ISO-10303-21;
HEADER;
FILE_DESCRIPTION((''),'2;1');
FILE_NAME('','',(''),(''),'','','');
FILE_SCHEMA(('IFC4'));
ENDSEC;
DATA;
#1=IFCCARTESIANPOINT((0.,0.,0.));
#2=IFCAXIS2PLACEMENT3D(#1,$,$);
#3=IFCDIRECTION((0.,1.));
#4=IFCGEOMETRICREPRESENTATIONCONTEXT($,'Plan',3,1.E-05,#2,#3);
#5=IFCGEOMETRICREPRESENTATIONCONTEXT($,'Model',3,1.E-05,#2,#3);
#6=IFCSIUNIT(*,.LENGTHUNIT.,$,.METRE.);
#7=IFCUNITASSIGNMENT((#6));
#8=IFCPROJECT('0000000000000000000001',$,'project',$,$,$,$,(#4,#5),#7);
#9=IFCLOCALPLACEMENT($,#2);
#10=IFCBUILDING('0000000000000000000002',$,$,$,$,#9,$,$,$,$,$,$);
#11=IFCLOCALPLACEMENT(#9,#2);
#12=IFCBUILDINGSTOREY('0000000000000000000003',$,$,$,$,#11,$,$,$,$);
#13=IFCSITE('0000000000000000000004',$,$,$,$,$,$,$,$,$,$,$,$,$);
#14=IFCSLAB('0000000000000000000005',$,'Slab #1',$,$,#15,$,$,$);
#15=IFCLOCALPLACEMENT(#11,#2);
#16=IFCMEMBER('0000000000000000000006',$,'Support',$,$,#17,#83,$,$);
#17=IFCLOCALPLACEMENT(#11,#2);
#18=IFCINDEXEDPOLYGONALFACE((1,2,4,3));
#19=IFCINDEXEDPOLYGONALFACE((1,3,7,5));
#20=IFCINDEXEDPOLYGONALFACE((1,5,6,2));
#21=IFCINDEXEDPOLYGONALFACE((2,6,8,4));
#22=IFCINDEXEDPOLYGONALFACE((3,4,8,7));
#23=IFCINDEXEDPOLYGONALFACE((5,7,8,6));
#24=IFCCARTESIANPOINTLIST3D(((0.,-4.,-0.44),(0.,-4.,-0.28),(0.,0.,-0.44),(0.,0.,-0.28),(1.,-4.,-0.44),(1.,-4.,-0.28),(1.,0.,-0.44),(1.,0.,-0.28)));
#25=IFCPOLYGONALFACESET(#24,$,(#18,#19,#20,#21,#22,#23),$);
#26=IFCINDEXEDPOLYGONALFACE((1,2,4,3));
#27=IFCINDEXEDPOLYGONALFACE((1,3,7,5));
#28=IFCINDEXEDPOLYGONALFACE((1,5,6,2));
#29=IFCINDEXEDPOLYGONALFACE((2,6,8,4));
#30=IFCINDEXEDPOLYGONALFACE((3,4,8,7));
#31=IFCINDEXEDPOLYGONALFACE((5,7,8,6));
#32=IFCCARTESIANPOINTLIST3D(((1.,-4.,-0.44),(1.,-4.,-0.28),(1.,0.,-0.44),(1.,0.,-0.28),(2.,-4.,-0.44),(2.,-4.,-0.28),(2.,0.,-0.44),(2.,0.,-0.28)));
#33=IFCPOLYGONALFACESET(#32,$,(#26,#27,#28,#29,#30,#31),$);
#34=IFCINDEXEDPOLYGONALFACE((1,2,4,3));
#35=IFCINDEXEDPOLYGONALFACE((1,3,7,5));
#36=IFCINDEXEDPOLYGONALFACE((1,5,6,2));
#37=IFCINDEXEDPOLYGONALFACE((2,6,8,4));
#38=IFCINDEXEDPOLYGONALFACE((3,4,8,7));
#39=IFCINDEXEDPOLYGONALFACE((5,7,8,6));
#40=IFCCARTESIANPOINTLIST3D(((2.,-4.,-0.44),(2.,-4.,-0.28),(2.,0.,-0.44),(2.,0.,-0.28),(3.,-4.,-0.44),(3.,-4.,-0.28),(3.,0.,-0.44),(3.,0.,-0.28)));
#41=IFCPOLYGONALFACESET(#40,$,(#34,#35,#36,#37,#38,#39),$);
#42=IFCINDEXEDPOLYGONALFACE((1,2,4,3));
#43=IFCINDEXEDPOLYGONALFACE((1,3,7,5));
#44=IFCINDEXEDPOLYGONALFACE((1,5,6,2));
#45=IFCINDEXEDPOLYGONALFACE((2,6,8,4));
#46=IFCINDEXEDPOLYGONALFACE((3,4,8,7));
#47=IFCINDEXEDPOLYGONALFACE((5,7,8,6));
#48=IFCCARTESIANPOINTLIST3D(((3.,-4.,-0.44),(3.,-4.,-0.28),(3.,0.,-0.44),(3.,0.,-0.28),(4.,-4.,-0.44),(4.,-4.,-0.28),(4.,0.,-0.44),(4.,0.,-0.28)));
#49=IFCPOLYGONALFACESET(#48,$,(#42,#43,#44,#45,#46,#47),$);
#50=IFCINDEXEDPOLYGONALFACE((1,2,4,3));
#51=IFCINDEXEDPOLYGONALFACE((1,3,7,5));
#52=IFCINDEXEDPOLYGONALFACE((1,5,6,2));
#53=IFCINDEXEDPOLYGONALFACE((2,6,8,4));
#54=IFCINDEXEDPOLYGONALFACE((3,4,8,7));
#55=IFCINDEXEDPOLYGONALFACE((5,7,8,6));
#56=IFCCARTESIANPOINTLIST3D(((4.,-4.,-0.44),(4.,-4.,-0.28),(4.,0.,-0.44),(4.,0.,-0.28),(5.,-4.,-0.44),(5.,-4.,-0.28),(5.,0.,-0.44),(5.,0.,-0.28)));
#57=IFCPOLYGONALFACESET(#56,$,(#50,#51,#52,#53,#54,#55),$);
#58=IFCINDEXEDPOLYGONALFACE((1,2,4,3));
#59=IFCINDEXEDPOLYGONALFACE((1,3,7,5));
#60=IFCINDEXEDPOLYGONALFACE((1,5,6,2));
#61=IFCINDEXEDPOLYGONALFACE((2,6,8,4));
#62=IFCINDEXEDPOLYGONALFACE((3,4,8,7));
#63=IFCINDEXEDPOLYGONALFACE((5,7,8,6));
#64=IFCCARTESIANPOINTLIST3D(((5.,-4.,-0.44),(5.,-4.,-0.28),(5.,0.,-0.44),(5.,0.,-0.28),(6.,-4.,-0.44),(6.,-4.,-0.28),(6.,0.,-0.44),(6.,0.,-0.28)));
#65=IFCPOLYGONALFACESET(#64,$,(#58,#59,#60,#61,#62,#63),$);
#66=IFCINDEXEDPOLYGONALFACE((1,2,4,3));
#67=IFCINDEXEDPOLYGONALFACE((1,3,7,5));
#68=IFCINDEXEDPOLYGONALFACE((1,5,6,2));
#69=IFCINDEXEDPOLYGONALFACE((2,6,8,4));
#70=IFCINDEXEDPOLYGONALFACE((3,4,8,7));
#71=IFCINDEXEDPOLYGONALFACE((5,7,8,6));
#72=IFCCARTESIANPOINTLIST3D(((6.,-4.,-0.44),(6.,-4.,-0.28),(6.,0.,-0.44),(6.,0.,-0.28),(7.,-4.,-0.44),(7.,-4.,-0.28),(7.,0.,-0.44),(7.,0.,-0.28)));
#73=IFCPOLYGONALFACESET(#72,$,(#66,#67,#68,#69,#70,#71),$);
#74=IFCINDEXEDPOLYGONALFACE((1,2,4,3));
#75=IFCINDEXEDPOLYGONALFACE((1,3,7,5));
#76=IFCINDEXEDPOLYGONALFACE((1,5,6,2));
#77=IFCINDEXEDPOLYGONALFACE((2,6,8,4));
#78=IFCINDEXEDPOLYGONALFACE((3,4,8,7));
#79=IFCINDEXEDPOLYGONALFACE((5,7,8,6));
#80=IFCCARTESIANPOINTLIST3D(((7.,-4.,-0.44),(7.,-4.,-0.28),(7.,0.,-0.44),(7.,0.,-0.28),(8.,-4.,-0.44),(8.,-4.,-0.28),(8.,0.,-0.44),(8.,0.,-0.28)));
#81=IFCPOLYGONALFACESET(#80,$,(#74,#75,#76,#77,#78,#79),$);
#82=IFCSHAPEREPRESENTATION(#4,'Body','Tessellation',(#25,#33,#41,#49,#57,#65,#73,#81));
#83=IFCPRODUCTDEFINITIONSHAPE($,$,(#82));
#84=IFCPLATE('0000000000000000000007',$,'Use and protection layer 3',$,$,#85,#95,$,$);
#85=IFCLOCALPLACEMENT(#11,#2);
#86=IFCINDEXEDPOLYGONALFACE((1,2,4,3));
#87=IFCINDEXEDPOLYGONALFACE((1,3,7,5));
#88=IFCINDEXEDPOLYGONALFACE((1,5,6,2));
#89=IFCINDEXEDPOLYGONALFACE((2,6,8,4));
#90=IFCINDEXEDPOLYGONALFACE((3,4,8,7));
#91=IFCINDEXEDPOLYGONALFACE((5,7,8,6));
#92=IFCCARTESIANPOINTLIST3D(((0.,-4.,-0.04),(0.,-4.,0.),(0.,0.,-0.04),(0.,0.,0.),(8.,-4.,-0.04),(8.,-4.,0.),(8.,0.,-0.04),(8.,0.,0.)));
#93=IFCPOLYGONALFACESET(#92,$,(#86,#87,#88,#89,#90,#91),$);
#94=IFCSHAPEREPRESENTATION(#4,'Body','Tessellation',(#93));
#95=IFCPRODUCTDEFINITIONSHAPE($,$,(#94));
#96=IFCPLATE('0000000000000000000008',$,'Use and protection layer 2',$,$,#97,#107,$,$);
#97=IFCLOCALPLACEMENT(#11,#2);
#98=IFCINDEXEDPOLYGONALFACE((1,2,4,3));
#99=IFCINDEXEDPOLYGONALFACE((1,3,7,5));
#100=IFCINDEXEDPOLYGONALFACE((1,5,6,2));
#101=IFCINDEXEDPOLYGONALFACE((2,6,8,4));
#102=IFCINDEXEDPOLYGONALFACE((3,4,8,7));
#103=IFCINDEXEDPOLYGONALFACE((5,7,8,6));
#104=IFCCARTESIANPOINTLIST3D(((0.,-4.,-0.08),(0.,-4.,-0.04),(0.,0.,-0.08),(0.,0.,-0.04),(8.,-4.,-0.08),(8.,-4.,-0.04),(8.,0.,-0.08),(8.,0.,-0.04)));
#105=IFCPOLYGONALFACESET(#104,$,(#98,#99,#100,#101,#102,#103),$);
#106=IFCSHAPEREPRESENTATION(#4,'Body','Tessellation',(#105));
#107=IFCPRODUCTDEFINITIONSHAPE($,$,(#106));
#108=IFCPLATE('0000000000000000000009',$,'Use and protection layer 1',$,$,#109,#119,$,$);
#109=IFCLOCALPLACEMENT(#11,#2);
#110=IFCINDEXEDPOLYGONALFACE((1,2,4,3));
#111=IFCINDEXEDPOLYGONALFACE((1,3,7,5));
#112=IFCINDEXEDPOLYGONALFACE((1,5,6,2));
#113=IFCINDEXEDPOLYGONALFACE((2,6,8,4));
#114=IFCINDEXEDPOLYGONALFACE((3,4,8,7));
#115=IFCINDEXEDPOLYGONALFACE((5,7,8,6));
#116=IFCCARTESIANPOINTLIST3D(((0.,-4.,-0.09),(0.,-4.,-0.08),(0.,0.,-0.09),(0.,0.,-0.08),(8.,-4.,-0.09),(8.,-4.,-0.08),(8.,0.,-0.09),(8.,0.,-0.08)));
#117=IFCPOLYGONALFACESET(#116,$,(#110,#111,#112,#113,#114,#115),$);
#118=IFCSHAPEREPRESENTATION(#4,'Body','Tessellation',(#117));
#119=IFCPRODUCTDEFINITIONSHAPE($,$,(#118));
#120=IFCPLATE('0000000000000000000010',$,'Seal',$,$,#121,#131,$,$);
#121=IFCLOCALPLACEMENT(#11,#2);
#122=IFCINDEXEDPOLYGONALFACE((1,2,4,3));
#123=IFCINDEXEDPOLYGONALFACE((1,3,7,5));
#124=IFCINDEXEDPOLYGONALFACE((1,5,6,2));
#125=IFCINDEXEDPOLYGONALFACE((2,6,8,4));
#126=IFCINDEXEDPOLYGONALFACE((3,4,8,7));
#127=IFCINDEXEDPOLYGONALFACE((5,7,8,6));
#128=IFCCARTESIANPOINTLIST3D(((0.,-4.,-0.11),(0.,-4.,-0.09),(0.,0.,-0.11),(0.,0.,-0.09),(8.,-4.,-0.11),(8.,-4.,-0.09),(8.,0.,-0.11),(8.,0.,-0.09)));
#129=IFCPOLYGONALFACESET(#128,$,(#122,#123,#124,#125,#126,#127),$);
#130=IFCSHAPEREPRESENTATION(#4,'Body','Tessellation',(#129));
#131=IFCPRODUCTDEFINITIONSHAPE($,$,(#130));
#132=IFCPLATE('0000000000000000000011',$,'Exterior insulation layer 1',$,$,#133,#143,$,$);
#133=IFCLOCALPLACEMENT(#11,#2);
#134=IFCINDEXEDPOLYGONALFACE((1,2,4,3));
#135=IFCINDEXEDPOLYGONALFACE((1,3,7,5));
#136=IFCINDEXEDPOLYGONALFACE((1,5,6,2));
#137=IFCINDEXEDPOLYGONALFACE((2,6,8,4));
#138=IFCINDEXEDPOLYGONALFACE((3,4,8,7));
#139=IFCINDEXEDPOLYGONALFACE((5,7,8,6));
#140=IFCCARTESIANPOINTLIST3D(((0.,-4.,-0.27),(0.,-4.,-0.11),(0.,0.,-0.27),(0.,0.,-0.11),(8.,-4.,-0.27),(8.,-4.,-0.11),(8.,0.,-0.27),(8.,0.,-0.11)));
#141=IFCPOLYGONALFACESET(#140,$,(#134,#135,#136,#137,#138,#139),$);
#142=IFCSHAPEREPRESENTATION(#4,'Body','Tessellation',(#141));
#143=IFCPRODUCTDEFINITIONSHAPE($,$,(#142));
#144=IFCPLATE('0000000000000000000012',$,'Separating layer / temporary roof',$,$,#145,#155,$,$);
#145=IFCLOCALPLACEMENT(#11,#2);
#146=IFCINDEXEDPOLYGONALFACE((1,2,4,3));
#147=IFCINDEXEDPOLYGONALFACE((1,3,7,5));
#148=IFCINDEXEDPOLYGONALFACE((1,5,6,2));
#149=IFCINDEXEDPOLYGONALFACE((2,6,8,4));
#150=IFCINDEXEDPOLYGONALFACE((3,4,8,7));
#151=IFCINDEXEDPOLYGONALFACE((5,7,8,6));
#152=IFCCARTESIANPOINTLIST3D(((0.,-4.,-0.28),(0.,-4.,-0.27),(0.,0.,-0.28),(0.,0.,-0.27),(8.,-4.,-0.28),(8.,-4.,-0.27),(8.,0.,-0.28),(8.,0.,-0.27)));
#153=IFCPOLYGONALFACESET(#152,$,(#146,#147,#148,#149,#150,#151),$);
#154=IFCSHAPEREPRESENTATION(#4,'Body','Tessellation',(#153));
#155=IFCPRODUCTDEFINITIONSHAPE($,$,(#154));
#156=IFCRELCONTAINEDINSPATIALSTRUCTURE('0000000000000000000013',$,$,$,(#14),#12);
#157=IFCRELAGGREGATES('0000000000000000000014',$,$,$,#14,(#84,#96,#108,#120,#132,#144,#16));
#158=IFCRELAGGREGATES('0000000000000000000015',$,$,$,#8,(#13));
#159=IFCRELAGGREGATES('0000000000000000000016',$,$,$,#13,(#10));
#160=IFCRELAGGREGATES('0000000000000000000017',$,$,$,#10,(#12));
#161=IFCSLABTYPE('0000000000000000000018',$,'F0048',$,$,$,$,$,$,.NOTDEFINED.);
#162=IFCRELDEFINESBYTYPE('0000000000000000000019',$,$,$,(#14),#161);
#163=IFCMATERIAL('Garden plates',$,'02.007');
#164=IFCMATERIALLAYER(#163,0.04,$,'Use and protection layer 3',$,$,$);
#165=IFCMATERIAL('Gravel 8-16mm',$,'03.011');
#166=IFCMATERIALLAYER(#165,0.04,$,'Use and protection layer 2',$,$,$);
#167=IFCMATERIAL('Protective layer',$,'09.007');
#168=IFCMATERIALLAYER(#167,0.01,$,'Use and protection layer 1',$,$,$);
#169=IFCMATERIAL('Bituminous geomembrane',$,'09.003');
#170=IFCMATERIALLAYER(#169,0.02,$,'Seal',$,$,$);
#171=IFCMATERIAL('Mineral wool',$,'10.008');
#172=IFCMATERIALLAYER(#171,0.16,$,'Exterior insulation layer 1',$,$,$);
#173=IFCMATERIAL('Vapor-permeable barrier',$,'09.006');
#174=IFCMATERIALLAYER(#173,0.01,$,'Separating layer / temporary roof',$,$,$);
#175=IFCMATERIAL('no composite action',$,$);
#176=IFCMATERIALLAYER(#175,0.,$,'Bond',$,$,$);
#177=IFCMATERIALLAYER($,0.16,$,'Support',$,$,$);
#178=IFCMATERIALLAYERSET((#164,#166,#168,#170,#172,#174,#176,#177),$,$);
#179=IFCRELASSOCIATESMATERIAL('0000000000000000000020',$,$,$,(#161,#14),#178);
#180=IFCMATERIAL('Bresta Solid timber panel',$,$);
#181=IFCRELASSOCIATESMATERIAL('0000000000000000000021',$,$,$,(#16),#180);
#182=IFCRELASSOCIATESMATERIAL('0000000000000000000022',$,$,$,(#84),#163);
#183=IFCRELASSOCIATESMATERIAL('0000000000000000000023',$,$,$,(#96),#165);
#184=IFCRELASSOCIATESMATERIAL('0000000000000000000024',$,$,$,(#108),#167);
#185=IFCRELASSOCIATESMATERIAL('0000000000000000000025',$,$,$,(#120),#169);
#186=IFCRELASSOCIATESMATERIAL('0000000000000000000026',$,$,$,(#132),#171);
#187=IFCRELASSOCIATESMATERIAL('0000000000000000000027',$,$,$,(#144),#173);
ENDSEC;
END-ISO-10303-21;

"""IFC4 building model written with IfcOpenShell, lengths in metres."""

from ifc_helpers import new_model, si_unit, direction, frame, frame_2d, origin, origin_with_axes, place, context, project, spatial, rectangle, extrude, material, layer, layer_set, type_object, element, aggregate, save


model = new_model("IFC4")

# Units and contexts
plan_context = context("Plan", 3, precision=1e-05, world=origin(), true_north=direction((0.0, 1.0)))
model_context = context("Model", 3, precision=1e-05, world=origin(), true_north=direction((0.0, 1.0)))
ifc_project = project(units=[si_unit("LENGTHUNIT", "METRE")], contexts=[plan_context, model_context])

# Site, building, storey
site = spatial("IfcSite", under=ifc_project)
building_placement = place(None, origin())
building = spatial("IfcBuilding", under=site, at=building_placement)
storey_placement = place(building_placement, origin())
storey = spatial("IfcBuildingStorey", under=building, at=storey_placement)

# Slab, member, plates
ifc_material_1 = material(Name="Garden plates", Category="02.007")
ifc_layer_1 = layer(ifc_material_1, 0.04, Name="Use and protection layer 3")
ifc_material_2 = material(Name="Gravel 8-16mm", Category="03.011")
ifc_layer_2 = layer(ifc_material_2, 0.04, Name="Use and protection layer 2")
ifc_material_3 = material(Name="Protective layer", Category="09.007")
ifc_layer_3 = layer(ifc_material_3, 0.01, Name="Use and protection layer 1")
ifc_material_4 = material(Name="Bituminous geomembrane", Category="09.003")
ifc_layer_4 = layer(ifc_material_4, 0.02, Name="Seal")
ifc_material_5 = material(Name="Mineral wool", Category="10.008")
ifc_layer_5 = layer(ifc_material_5, 0.16, Name="Exterior insulation layer 1")
ifc_material_6 = material(Name="Vapor-permeable barrier", Category="09.006")
ifc_layer_6 = layer(ifc_material_6, 0.01, Name="Separating layer / temporary roof")
ifc_material_7 = material(Name="no composite action")
ifc_layer_7 = layer(ifc_material_7, 0.0, Name="Bond")
ifc_layer_8 = layer(None, 0.16, Name="Support")
ifc_layer_set = layer_set([ifc_layer_1, ifc_layer_2, ifc_layer_3, ifc_layer_4, ifc_layer_5, ifc_layer_6, ifc_layer_7, ifc_layer_8])
slab_type = type_object("IfcSlabType", Name="F0048", PredefinedType="NOTDEFINED", material=ifc_layer_set)
slab_placement = place(None, frame((0.0, 0.0, 0.0), z_axis=(0.0, 0.0, -1.0), x_axis=(1.0, 0.0, 0.0)))
slab = element("IfcSlab", 1, at=slab_placement, inside=storey, type_object=slab_type, material=ifc_layer_set, Name="Slab #1")
ifc_material_8 = material(Name="Bresta Solid timber panel")
member_placement = place(slab_placement, origin())
member = element("IfcMember", 2, at=member_placement, material=ifc_material_8, Name="Support", context=plan_context, shape_type="SweptSolid", body=[
    extrude(rectangle(XDim=1.0, YDim=0.16, at=frame_2d((0.5, 0.08), x_axis=(1.0, 0.0))), frame((0.0, 4.0, 0.28), z_axis=(0.0, -1.0, 0.0), x_axis=(1.0, 0.0, 0.0)), (0.0, 0.0, 1.0), 4.0),
    extrude(rectangle(XDim=1.0, YDim=0.16, at=frame_2d((0.5, 0.08), x_axis=(1.0, 0.0))), frame((1.0, 4.0, 0.28), z_axis=(0.0, -1.0, 0.0), x_axis=(1.0, 0.0, 0.0)), (0.0, 0.0, 1.0), 4.0),
    extrude(rectangle(XDim=1.0, YDim=0.16, at=frame_2d((0.5, 0.08), x_axis=(1.0, 0.0))), frame((2.0, 4.0, 0.28), z_axis=(0.0, -1.0, 0.0), x_axis=(1.0, 0.0, 0.0)), (0.0, 0.0, 1.0), 4.0),
    extrude(rectangle(XDim=1.0, YDim=0.16, at=frame_2d((0.5, 0.08), x_axis=(1.0, 0.0))), frame((3.0, 4.0, 0.28), z_axis=(0.0, -1.0, 0.0), x_axis=(1.0, 0.0, 0.0)), (0.0, 0.0, 1.0), 4.0),
    extrude(rectangle(XDim=1.0, YDim=0.16, at=frame_2d((0.5, 0.08), x_axis=(1.0, 0.0))), frame((4.0, 4.0, 0.28), z_axis=(0.0, -1.0, 0.0), x_axis=(1.0, 0.0, 0.0)), (0.0, 0.0, 1.0), 4.0),
    extrude(rectangle(XDim=1.0, YDim=0.16, at=frame_2d((0.5, 0.08), x_axis=(1.0, 0.0))), frame((5.0, 4.0, 0.28), z_axis=(0.0, -1.0, 0.0), x_axis=(1.0, 0.0, 0.0)), (0.0, 0.0, 1.0), 4.0),
    extrude(rectangle(XDim=1.0, YDim=0.16, at=frame_2d((0.5, 0.08), x_axis=(1.0, 0.0))), frame((6.0, 4.0, 0.28), z_axis=(0.0, -1.0, 0.0), x_axis=(1.0, 0.0, 0.0)), (0.0, 0.0, 1.0), 4.0),
    extrude(rectangle(XDim=1.0, YDim=0.16, at=frame_2d((0.5, 0.08), x_axis=(1.0, 0.0))), frame((7.0, 4.0, 0.28), z_axis=(0.0, -1.0, 0.0), x_axis=(1.0, 0.0, 0.0)), (0.0, 0.0, 1.0), 4.0),
])
plate_1_placement = place(slab_placement, origin())
plate_1 = element("IfcPlate", 3, at=plate_1_placement, material=ifc_material_1, Name="Use and protection layer 3", context=plan_context, shape_type="SweptSolid", body=[
    extrude(rectangle(XDim=8.0, YDim=4.0, at=frame_2d((4.0, 2.0), x_axis=(1.0, 0.0))), origin_with_axes(), (0.0, 0.0, 1.0), 0.04),
])
plate_2_placement = place(slab_placement, origin())
plate_2 = element("IfcPlate", 4, at=plate_2_placement, material=ifc_material_2, Name="Use and protection layer 2", context=plan_context, shape_type="SweptSolid", body=[
    extrude(rectangle(XDim=8.0, YDim=4.0, at=frame_2d((4.0, 2.0), x_axis=(1.0, 0.0))), frame((0.0, 0.0, 0.04), z_axis=(0.0, 0.0, 1.0), x_axis=(1.0, 0.0, 0.0)), (0.0, 0.0, 1.0), 0.04),
])
plate_3_placement = place(slab_placement, origin())
plate_3 = element("IfcPlate", 5, at=plate_3_placement, material=ifc_material_3, Name="Use and protection layer 1", context=plan_context, shape_type="SweptSolid", body=[
    extrude(rectangle(XDim=8.0, YDim=4.0, at=frame_2d((4.0, 2.0), x_axis=(1.0, 0.0))), frame((0.0, 0.0, 0.08), z_axis=(0.0, 0.0, 1.0), x_axis=(1.0, 0.0, 0.0)), (0.0, 0.0, 1.0), 0.01),
])
plate_4_placement = place(slab_placement, origin())
plate_4 = element("IfcPlate", 6, at=plate_4_placement, material=ifc_material_4, Name="Seal", context=plan_context, shape_type="SweptSolid", body=[
    extrude(rectangle(XDim=8.0, YDim=4.0, at=frame_2d((4.0, 2.0), x_axis=(1.0, 0.0))), frame((0.0, 0.0, 0.09), z_axis=(0.0, 0.0, 1.0), x_axis=(1.0, 0.0, 0.0)), (0.0, 0.0, 1.0), 0.02),
])
plate_5_placement = place(slab_placement, origin())
plate_5 = element("IfcPlate", 7, at=plate_5_placement, material=ifc_material_5, Name="Exterior insulation layer 1", context=plan_context, shape_type="SweptSolid", body=[
    extrude(rectangle(XDim=8.0, YDim=4.0, at=frame_2d((4.0, 2.0), x_axis=(1.0, 0.0))), frame((0.0, 0.0, 0.11), z_axis=(0.0, 0.0, 1.0), x_axis=(1.0, 0.0, 0.0)), (0.0, 0.0, 1.0), 0.16),
])
plate_6_placement = place(slab_placement, origin())
plate_6 = element("IfcPlate", 8, at=plate_6_placement, material=ifc_material_6, Name="Separating layer / temporary roof", context=plan_context, shape_type="SweptSolid", body=[
    extrude(rectangle(XDim=8.0, YDim=4.0, at=frame_2d((4.0, 2.0), x_axis=(1.0, 0.0))), frame((0.0, 0.0, 0.27), z_axis=(0.0, 0.0, 1.0), x_axis=(1.0, 0.0, 0.0)), (0.0, 0.0, 1.0), 0.01),
])
aggregate(slab, [plate_1, plate_2, plate_3, plate_4, plate_5, plate_6, member])

save(model, "model.ifc")
